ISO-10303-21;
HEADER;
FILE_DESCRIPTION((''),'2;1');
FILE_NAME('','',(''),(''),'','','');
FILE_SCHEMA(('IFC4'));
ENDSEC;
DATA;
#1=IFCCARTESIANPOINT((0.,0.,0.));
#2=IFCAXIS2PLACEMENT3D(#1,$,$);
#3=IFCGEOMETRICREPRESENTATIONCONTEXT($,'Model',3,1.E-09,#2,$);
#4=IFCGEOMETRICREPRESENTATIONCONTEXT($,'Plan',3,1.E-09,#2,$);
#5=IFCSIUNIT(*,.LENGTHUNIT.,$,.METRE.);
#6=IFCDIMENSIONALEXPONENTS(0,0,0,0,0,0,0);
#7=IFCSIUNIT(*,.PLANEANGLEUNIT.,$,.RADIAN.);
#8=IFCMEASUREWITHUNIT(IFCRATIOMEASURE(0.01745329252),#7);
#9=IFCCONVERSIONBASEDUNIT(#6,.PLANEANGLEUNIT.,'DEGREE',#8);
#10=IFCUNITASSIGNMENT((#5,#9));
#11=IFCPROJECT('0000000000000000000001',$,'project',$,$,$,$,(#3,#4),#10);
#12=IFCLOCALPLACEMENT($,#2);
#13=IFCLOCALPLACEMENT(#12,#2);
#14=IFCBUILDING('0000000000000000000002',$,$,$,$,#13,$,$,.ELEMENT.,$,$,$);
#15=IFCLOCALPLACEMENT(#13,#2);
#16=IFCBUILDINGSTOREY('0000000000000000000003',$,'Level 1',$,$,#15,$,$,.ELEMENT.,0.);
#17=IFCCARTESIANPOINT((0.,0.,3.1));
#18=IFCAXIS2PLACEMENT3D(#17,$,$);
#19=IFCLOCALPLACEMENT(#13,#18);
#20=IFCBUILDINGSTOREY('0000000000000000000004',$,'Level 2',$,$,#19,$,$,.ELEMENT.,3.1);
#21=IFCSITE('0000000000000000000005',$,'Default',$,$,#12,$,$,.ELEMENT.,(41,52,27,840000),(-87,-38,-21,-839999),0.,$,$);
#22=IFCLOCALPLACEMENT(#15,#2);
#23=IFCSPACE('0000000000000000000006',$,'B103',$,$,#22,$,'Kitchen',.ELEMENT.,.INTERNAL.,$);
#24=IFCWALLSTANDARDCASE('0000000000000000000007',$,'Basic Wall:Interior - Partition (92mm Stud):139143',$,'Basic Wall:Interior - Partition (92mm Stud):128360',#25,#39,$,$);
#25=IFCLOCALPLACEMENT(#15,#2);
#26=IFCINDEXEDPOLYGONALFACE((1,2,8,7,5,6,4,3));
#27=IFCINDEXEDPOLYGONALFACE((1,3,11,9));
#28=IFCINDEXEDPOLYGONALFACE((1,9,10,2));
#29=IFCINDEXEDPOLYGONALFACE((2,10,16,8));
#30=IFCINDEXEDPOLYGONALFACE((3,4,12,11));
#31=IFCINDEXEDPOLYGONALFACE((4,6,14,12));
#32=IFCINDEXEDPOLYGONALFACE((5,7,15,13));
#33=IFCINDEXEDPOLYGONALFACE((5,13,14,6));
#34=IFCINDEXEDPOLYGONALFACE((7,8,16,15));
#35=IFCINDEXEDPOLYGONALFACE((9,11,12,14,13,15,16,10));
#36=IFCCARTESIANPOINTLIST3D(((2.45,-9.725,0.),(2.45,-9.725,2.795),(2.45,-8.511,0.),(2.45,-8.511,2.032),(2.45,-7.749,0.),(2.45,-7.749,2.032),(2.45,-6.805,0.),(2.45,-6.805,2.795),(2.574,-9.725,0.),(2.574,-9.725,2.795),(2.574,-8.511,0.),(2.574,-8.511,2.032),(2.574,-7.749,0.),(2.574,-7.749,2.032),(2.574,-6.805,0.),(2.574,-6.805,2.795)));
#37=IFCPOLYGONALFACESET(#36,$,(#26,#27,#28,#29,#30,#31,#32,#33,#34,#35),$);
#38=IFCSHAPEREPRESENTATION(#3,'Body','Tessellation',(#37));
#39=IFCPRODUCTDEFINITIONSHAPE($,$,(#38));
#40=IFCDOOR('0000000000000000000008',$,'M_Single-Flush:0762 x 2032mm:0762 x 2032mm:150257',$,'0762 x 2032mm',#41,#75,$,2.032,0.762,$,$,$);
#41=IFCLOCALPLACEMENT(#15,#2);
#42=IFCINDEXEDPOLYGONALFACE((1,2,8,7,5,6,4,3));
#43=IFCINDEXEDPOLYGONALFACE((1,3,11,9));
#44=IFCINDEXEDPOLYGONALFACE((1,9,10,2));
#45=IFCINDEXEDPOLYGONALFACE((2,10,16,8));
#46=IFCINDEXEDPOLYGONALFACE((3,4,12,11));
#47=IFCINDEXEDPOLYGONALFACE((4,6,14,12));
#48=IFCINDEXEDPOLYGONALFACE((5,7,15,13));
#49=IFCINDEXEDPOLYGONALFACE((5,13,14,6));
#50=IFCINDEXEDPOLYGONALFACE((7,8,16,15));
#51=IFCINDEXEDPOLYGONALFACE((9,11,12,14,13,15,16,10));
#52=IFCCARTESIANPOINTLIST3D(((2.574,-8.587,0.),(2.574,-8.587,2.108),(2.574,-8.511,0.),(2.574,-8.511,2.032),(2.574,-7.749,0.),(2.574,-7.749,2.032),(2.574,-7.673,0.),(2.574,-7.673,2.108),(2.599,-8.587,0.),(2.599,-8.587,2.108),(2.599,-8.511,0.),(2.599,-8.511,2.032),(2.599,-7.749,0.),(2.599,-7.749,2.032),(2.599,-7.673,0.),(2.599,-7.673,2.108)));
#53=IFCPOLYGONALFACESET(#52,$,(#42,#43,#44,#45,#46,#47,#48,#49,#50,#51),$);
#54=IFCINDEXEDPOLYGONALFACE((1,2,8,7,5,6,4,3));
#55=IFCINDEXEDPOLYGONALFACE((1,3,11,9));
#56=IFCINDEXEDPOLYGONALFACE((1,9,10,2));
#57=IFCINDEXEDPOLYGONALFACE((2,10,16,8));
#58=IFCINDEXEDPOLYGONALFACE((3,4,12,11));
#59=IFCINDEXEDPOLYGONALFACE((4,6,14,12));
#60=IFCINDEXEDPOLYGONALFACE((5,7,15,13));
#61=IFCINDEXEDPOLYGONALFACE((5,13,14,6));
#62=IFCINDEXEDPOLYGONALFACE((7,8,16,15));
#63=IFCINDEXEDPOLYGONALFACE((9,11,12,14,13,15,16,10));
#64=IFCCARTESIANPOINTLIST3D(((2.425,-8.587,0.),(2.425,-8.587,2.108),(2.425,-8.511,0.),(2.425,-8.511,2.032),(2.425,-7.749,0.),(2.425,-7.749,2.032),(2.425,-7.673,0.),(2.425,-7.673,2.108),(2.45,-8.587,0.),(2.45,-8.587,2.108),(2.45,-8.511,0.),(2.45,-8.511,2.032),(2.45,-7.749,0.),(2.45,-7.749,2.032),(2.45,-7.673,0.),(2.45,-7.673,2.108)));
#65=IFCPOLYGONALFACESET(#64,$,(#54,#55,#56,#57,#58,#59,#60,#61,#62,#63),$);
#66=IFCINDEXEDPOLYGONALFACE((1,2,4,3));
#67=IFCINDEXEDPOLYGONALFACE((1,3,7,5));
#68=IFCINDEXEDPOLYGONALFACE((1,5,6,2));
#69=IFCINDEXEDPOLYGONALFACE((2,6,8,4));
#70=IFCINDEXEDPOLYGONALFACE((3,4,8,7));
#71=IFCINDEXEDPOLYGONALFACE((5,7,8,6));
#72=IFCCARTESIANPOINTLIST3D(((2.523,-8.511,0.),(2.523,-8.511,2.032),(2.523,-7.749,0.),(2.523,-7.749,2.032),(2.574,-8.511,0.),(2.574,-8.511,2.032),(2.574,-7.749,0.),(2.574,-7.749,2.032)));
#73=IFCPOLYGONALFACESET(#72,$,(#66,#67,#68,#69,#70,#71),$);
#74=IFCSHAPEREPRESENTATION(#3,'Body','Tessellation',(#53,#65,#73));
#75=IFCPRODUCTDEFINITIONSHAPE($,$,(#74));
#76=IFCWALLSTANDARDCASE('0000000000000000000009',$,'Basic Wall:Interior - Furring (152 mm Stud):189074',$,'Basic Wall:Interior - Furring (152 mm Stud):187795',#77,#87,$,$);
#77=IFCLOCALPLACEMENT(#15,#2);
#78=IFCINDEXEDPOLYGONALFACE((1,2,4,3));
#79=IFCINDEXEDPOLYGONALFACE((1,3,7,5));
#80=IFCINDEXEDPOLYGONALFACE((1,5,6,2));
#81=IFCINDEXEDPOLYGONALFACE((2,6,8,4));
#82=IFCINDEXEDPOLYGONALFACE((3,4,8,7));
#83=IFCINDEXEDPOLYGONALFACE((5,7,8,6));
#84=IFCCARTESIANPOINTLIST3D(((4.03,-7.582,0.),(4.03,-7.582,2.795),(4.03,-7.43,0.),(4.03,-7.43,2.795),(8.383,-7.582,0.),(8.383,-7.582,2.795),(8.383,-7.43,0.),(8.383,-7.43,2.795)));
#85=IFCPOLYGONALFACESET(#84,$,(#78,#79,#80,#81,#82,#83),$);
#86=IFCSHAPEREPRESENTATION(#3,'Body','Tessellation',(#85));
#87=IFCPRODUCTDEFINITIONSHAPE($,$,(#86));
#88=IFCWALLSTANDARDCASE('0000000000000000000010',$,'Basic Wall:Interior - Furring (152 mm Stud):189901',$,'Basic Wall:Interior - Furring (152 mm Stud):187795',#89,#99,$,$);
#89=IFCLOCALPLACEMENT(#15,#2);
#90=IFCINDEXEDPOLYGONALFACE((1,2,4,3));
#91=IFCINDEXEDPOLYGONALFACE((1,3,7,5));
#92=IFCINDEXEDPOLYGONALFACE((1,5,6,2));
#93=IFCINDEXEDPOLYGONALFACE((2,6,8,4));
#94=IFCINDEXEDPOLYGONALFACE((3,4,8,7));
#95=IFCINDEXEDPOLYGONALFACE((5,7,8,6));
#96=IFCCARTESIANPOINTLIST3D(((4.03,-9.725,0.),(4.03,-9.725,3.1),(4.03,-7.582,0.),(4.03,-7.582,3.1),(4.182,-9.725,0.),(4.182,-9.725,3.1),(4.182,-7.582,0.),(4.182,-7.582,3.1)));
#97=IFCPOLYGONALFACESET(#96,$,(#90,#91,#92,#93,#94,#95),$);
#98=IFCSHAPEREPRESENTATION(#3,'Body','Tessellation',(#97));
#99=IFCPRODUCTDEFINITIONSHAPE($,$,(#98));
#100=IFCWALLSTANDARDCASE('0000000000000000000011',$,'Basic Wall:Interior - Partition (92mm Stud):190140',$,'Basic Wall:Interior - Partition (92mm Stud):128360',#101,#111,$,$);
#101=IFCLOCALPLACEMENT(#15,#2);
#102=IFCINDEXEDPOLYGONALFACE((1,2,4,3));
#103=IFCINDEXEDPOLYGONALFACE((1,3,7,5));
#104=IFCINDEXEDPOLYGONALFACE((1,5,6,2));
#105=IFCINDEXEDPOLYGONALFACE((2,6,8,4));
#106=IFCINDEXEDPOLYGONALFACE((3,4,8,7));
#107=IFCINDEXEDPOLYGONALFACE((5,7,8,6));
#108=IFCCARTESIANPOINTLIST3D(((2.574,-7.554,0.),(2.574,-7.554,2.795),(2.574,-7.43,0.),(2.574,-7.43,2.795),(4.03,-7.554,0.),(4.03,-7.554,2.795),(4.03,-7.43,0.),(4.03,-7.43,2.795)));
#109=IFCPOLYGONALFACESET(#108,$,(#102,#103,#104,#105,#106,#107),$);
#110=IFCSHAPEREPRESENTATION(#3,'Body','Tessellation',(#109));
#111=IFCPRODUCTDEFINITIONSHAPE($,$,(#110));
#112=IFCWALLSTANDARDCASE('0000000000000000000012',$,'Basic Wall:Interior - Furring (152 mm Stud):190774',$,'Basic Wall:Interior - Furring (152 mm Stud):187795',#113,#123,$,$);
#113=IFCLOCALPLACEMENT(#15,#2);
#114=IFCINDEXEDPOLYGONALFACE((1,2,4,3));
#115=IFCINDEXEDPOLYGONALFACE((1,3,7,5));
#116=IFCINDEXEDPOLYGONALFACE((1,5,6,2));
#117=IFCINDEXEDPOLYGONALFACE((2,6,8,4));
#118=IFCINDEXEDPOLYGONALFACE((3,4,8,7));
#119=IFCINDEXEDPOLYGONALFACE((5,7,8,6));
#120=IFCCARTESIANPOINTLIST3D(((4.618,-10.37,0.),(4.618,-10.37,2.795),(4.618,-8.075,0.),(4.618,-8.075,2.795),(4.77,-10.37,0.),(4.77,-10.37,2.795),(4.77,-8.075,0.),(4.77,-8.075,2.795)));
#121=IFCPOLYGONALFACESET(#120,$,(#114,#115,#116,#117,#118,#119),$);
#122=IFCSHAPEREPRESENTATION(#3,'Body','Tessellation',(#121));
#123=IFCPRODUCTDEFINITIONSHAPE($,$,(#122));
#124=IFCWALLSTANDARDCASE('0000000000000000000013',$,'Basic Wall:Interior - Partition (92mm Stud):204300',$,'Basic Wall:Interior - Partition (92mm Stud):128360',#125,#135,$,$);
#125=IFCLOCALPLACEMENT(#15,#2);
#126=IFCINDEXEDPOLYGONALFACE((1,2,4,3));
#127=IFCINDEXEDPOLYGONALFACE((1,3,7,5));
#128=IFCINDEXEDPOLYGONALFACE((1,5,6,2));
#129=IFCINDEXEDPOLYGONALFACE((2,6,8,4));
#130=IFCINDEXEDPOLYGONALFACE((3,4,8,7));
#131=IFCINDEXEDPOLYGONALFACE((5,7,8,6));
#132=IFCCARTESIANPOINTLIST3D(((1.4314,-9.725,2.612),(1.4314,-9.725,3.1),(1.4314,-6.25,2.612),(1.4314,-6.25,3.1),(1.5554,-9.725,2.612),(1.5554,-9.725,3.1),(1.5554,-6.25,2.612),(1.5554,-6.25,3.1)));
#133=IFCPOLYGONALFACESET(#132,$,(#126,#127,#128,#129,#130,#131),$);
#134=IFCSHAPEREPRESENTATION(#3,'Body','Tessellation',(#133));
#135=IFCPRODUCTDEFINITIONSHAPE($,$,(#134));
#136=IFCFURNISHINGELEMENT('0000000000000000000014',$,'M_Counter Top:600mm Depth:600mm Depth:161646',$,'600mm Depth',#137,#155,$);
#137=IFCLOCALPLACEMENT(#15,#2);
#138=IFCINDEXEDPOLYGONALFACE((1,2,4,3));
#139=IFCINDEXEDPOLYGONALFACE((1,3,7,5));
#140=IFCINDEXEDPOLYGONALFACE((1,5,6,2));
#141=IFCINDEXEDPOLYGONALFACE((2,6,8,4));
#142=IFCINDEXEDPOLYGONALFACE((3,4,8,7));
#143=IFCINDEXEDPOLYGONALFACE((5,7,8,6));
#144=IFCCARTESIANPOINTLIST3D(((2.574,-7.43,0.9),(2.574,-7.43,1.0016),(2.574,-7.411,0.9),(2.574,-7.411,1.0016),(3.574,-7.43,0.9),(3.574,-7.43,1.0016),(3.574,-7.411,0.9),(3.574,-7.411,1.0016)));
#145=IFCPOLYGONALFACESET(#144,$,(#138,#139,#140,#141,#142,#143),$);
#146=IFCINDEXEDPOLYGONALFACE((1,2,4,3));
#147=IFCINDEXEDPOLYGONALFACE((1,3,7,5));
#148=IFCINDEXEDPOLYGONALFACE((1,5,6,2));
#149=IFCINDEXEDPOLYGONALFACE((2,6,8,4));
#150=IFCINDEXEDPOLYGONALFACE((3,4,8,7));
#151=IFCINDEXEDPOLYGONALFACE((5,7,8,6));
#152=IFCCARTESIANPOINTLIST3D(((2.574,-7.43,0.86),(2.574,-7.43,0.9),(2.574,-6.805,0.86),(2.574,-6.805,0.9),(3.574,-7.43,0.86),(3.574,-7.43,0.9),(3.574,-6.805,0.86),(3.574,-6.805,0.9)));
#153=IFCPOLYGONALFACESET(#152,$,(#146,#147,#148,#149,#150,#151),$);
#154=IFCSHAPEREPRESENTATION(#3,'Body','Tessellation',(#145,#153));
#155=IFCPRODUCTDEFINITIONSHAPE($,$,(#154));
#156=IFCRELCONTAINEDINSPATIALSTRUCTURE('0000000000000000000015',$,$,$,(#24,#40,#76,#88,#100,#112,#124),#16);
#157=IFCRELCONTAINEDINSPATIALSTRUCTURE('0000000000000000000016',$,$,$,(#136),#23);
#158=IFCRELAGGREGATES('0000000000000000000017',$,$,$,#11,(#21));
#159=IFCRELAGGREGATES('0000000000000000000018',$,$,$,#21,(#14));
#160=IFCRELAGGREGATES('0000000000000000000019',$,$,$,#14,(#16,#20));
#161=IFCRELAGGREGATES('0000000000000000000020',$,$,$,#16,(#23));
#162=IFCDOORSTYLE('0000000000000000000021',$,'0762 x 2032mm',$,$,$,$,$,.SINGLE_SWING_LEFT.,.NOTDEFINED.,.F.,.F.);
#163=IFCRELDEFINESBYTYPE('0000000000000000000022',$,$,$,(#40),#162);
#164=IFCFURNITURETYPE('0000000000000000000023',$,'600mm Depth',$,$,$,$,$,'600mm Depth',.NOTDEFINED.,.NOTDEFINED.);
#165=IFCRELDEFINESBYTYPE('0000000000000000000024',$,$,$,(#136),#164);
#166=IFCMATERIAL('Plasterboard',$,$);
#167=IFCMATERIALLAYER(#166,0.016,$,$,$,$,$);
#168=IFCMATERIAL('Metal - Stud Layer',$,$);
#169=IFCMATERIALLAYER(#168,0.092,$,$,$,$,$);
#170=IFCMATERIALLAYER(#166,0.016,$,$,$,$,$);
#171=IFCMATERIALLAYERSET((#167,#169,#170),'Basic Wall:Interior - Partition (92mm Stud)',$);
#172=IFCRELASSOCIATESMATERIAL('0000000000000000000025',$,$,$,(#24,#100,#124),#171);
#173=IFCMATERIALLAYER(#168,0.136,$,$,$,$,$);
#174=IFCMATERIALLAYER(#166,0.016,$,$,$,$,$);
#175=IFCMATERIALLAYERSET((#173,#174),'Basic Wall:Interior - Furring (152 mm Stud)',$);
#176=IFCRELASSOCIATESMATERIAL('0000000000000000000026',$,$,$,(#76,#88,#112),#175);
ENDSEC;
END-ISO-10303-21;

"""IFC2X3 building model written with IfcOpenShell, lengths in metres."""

from ifc_helpers import new_model, entity, si_unit, converted_unit, frame, frame_2d, origin, origin_2d_with_axis, place, context, project, spatial, polyline, rectangle, outline, extrude, clip, bounded_halfspace, source, transform, mapped, material, layer, layer_set, layer_usage, type_object, type_shapes, element, fill, save


model = new_model("IFC2X3")

# Units and contexts
model_context = context("Model", 3, precision=1e-09, world=origin())
plan_context = context("Plan", 3, precision=1e-09, world=origin())
ifc_project = project(units=[si_unit("LENGTHUNIT", "METRE"), converted_unit("PLANEANGLEUNIT", "DEGREE", entity("IfcRatioMeasure", 0.01745329252), si_unit("PLANEANGLEUNIT", "RADIAN"), dimensions=[0, 0, 0, 0, 0, 0, 0])], contexts=[model_context, plan_context])

# Site, building, storey
site_placement = place(None, origin())
site = spatial("IfcSite", under=ifc_project, at=site_placement, Name="Default", CompositionType="ELEMENT", RefLatitude=(41, 52, 27, 840000), RefLongitude=(-87, -38, -21, -839999), RefElevation=0.0)
building_placement = place(site_placement, origin())
building = spatial("IfcBuilding", under=site, at=building_placement, CompositionType="ELEMENT")
storey_1_placement = place(building_placement, origin())
storey_1 = spatial("IfcBuildingStorey", under=building, at=storey_1_placement, Name="Level 1", CompositionType="ELEMENT", Elevation=0.0)

# Shared definitions
ifc_material_1 = material(Name="Metal - Stud Layer")
ifc_material_2 = material(Name="Plasterboard")

# Shared definitions
ifc_layer_1 = layer(ifc_material_2, 0.016)
ifc_layer_2 = layer(ifc_material_1, 0.092)
ifc_layer_3 = layer(ifc_material_2, 0.016)
ifc_layer_set_1 = layer_set([ifc_layer_1, ifc_layer_2, ifc_layer_3], Name="Basic Wall:Interior - Partition (92mm Stud)")

# Wall, opening, door
ifc_layer_usage_1 = layer_usage(ifc_layer_set_1, "AXIS2", "NEGATIVE", 0.062)
wall_1_placement = place(storey_1_placement, frame((2.512, -6.805, 0.0), z_axis=(0.0, 0.0, 1.0), x_axis=(0.0, -1.0, 0.0)))
wall_1 = element("IfcWallStandardCase", 1, at=wall_1_placement, inside=storey_1, material=ifc_layer_usage_1, Name="Basic Wall:Interior - Partition (92mm Stud):139143", ObjectType="Basic Wall:Interior - Partition (92mm Stud):128360", context=model_context, shape_type="SweptSolid", body=[
    extrude(rectangle(XDim=2.92, YDim=0.124, at=frame_2d((1.46, 0.0), x_axis=(-1.0, 0.0))), origin(), (0.0, 0.0, 1.0), 2.795),
])
opening_1_placement = place(wall_1_placement, frame((0.944, -0.062, 0.0)))
opening_1 = element("IfcOpeningElement", 2, at=opening_1_placement, cuts=wall_1, ObjectType="Opening", context=model_context, shape_type="SweptSolid", body=[
    extrude(rectangle(XDim=0.762, YDim=2.032, at=frame_2d((1.016, 0.381), x_axis=(0.0, -1.0))), frame((0.0, 0.0, 0.0), z_axis=(0.0, 1.0, 0.0), x_axis=(0.0, 0.0, 1.0)), (0.0, 0.0, 1.0), 0.124),
])
door_style_1 = type_object("IfcDoorStyle", Name="0762 x 2032mm", ConstructionType="NOTDEFINED", OperationType="SINGLE_SWING_LEFT", ParameterTakesPrecedence=False, Sizeable=False)
shared_shape_1 = source(origin(), model_context, "Body", "SweptSolid", [
    extrude(outline(polyline([(-0.457, -1.073), (0.457, -1.073), (0.457, 1.035), (0.381, 1.035), (0.381, -0.997), (-0.381, -0.997), (-0.381, 1.035), (-0.457, 1.035), (-0.457, -1.073)])), frame((0.381, 0.149, 1.035), z_axis=(0.0, -1.0, 0.0), x_axis=(-1.0, 0.0, 0.0)), (0.0, 0.0, 1.0), 0.025),
    extrude(outline(polyline([(-1.073, -0.457), (1.035, -0.457), (1.035, -0.381), (-0.997, -0.381), (-0.997, 0.381), (1.035, 0.381), (1.035, 0.457), (-1.073, 0.457), (-1.073, -0.457)])), frame((0.381, 0.0, 1.035), z_axis=(0.0, -1.0, 0.0), x_axis=(0.0, 0.0, -1.0)), (0.0, 0.0, 1.0), 0.025),
    extrude(rectangle(XDim=0.762, YDim=0.051, at=origin_2d_with_axis()), frame((0.381, 0.0985, 0.0)), (0.0, 0.0, 1.0), 2.032),
])
type_shapes(door_style_1, [shared_shape_1])
door_1_placement = place(opening_1_placement, origin())
door_1 = element("IfcDoor", 3, at=door_1_placement, inside=storey_1, type_object=door_style_1, Name="M_Single-Flush:0762 x 2032mm:0762 x 2032mm:150257", ObjectType="0762 x 2032mm", OverallHeight=2.032, OverallWidth=0.762, context=model_context, shape_type="MappedRepresentation", body=[
    mapped(shared_shape_1, transform((0.0, 0.0, 0.0), scale=1.0)),
])
fill(opening_1, door_1)

# Shared definitions
storey_2_placement = place(building_placement, frame((0.0, 0.0, 3.1)))
storey_2 = spatial("IfcBuildingStorey", under=building, at=storey_2_placement, Name="Level 2", CompositionType="ELEMENT", Elevation=3.1)

# Walls
ifc_layer_4 = layer(ifc_material_1, 0.136)
ifc_layer_5 = layer(ifc_material_2, 0.016)
ifc_layer_set_2 = layer_set([ifc_layer_4, ifc_layer_5], Name="Basic Wall:Interior - Furring (152 mm Stud)")
ifc_layer_usage_2 = layer_usage(ifc_layer_set_2, "AXIS2", "NEGATIVE", 0.076)
wall_2_placement = place(storey_1_placement, frame((8.383, -7.506, 0.0), z_axis=(0.0, 0.0, 1.0), x_axis=(-1.0, 0.0, 0.0)))
element("IfcWallStandardCase", 4, at=wall_2_placement, inside=storey_1, material=ifc_layer_usage_2, Name="Basic Wall:Interior - Furring (152 mm Stud):189074", ObjectType="Basic Wall:Interior - Furring (152 mm Stud):187795", context=model_context, shape_type="Clipping", body=[
    clip(extrude(rectangle(XDim=4.353, YDim=0.152, at=frame_2d((2.1765, 0.0), x_axis=(-1.0, 0.0))), origin(), (0.0, 0.0, 1.0), 2.795), bounded_halfspace(frame((0.0, -0.076, 2.795), z_axis=(0.0, 0.0, -1.0), x_axis=(0.0, 1.0, 0.0)), True, frame((0.0, -0.076, 2.795)), polyline([(0.0, 0.0), (3.708, 0.0), (3.708, 0.152), (0.0, 0.152), (0.0, 0.0)]))),
])
ifc_layer_usage_3 = layer_usage(ifc_layer_set_2, "AXIS2", "POSITIVE", -0.076)
wall_3_placement = place(storey_1_placement, frame((4.106, -9.725, 0.0), z_axis=(0.0, 0.0, 1.0), x_axis=(0.0, 1.0, 0.0)))
element("IfcWallStandardCase", 5, at=wall_3_placement, inside=storey_1, material=ifc_layer_usage_3, Name="Basic Wall:Interior - Furring (152 mm Stud):189901", ObjectType="Basic Wall:Interior - Furring (152 mm Stud):187795", context=model_context, shape_type="SweptSolid", body=[
    extrude(rectangle(XDim=2.143, YDim=0.152, at=frame_2d((1.0715, 0.0), x_axis=(-1.0, 0.0))), origin(), (0.0, 0.0, 1.0), 3.1),
])
ifc_layer_usage_4 = layer_usage(ifc_layer_set_1, "AXIS2", "NEGATIVE", 0.062)
wall_4_placement = place(storey_1_placement, frame((4.03, -7.492, 0.0), z_axis=(0.0, 0.0, 1.0), x_axis=(-1.0, 0.0, 0.0)))
element("IfcWallStandardCase", 6, at=wall_4_placement, inside=storey_1, material=ifc_layer_usage_4, Name="Basic Wall:Interior - Partition (92mm Stud):190140", ObjectType="Basic Wall:Interior - Partition (92mm Stud):128360", context=model_context, shape_type="SweptSolid", body=[
    extrude(rectangle(XDim=1.456, YDim=0.124, at=frame_2d((0.728, 0.0), x_axis=(-1.0, 0.0))), origin(), (0.0, 0.0, 1.0), 2.795),
])
ifc_layer_usage_5 = layer_usage(ifc_layer_set_2, "AXIS2", "POSITIVE", -0.076)
wall_5_placement = place(storey_1_placement, frame((4.694, -8.075, 0.0), z_axis=(0.0, 0.0, 1.0), x_axis=(0.0, -1.0, 0.0)))
element("IfcWallStandardCase", 7, at=wall_5_placement, inside=storey_1, material=ifc_layer_usage_5, Name="Basic Wall:Interior - Furring (152 mm Stud):190774", ObjectType="Basic Wall:Interior - Furring (152 mm Stud):187795", context=model_context, shape_type="SweptSolid", body=[
    extrude(rectangle(XDim=2.295, YDim=0.152, at=frame_2d((1.1475, 0.0), x_axis=(-1.0, 0.0))), origin(), (0.0, 0.0, 1.0), 2.795),
])
ifc_layer_usage_6 = layer_usage(ifc_layer_set_1, "AXIS2", "NEGATIVE", 0.062)
wall_6_placement = place(storey_1_placement, frame((1.4934, -6.25, 2.612), z_axis=(0.0, 0.0, 1.0), x_axis=(0.0, -1.0, 0.0)))
element("IfcWallStandardCase", 8, at=wall_6_placement, inside=storey_1, material=ifc_layer_usage_6, Name="Basic Wall:Interior - Partition (92mm Stud):204300", ObjectType="Basic Wall:Interior - Partition (92mm Stud):128360", context=model_context, shape_type="SweptSolid", body=[
    extrude(rectangle(XDim=3.475, YDim=0.124, at=frame_2d((1.7375, 0.0), x_axis=(-1.0, 0.0))), origin(), (0.0, 0.0, 1.0), 0.488),
])

# Shared definitions
space_1_placement = place(storey_1_placement, origin())
space_1 = spatial("IfcSpace", under=storey_1, at=space_1_placement, Name="B103", LongName="Kitchen", CompositionType="ELEMENT", InteriorOrExteriorSpace="INTERNAL")

# Furnishing element
furniture_type_1 = type_object("IfcFurnitureType", Name="600mm Depth", ElementType="600mm Depth", AssemblyPlace="NOTDEFINED")
shared_shape_2 = source(origin(), model_context, "Body", "SweptSolid", [
    extrude(rectangle(XDim=0.0191, YDim=1.0, at=origin_2d_with_axis()), frame((-0.7005, -0.0095, 0.9), z_axis=(0.0, 0.0, 1.0), x_axis=(0.0, -1.0, 0.0)), (0.0, 0.0, 1.0), 0.1016),
    extrude(rectangle(XDim=1.0, YDim=0.625, at=origin_2d_with_axis()), frame((-0.7005, -0.3125, 0.86), z_axis=(0.0, 0.0, 1.0), x_axis=(-1.0, 0.0, 0.0)), (0.0, 0.0, 1.0), 0.04),
])
type_shapes(furniture_type_1, [shared_shape_2])
furnishing_1_placement = place(space_1_placement, frame((2.3735, -7.43, 0.0), z_axis=(0.0, 0.0, 1.0), x_axis=(-1.0, 0.0, 0.0)))
element("IfcFurnishingElement", 9, at=furnishing_1_placement, inside=space_1, type_object=furniture_type_1, Name="M_Counter Top:600mm Depth:600mm Depth:161646", ObjectType="600mm Depth", context=model_context, shape_type="MappedRepresentation", body=[
    mapped(shared_shape_2, transform((0.0, 0.0, 0.0), scale=1.0)),
])

save(model, "model.ifc")
